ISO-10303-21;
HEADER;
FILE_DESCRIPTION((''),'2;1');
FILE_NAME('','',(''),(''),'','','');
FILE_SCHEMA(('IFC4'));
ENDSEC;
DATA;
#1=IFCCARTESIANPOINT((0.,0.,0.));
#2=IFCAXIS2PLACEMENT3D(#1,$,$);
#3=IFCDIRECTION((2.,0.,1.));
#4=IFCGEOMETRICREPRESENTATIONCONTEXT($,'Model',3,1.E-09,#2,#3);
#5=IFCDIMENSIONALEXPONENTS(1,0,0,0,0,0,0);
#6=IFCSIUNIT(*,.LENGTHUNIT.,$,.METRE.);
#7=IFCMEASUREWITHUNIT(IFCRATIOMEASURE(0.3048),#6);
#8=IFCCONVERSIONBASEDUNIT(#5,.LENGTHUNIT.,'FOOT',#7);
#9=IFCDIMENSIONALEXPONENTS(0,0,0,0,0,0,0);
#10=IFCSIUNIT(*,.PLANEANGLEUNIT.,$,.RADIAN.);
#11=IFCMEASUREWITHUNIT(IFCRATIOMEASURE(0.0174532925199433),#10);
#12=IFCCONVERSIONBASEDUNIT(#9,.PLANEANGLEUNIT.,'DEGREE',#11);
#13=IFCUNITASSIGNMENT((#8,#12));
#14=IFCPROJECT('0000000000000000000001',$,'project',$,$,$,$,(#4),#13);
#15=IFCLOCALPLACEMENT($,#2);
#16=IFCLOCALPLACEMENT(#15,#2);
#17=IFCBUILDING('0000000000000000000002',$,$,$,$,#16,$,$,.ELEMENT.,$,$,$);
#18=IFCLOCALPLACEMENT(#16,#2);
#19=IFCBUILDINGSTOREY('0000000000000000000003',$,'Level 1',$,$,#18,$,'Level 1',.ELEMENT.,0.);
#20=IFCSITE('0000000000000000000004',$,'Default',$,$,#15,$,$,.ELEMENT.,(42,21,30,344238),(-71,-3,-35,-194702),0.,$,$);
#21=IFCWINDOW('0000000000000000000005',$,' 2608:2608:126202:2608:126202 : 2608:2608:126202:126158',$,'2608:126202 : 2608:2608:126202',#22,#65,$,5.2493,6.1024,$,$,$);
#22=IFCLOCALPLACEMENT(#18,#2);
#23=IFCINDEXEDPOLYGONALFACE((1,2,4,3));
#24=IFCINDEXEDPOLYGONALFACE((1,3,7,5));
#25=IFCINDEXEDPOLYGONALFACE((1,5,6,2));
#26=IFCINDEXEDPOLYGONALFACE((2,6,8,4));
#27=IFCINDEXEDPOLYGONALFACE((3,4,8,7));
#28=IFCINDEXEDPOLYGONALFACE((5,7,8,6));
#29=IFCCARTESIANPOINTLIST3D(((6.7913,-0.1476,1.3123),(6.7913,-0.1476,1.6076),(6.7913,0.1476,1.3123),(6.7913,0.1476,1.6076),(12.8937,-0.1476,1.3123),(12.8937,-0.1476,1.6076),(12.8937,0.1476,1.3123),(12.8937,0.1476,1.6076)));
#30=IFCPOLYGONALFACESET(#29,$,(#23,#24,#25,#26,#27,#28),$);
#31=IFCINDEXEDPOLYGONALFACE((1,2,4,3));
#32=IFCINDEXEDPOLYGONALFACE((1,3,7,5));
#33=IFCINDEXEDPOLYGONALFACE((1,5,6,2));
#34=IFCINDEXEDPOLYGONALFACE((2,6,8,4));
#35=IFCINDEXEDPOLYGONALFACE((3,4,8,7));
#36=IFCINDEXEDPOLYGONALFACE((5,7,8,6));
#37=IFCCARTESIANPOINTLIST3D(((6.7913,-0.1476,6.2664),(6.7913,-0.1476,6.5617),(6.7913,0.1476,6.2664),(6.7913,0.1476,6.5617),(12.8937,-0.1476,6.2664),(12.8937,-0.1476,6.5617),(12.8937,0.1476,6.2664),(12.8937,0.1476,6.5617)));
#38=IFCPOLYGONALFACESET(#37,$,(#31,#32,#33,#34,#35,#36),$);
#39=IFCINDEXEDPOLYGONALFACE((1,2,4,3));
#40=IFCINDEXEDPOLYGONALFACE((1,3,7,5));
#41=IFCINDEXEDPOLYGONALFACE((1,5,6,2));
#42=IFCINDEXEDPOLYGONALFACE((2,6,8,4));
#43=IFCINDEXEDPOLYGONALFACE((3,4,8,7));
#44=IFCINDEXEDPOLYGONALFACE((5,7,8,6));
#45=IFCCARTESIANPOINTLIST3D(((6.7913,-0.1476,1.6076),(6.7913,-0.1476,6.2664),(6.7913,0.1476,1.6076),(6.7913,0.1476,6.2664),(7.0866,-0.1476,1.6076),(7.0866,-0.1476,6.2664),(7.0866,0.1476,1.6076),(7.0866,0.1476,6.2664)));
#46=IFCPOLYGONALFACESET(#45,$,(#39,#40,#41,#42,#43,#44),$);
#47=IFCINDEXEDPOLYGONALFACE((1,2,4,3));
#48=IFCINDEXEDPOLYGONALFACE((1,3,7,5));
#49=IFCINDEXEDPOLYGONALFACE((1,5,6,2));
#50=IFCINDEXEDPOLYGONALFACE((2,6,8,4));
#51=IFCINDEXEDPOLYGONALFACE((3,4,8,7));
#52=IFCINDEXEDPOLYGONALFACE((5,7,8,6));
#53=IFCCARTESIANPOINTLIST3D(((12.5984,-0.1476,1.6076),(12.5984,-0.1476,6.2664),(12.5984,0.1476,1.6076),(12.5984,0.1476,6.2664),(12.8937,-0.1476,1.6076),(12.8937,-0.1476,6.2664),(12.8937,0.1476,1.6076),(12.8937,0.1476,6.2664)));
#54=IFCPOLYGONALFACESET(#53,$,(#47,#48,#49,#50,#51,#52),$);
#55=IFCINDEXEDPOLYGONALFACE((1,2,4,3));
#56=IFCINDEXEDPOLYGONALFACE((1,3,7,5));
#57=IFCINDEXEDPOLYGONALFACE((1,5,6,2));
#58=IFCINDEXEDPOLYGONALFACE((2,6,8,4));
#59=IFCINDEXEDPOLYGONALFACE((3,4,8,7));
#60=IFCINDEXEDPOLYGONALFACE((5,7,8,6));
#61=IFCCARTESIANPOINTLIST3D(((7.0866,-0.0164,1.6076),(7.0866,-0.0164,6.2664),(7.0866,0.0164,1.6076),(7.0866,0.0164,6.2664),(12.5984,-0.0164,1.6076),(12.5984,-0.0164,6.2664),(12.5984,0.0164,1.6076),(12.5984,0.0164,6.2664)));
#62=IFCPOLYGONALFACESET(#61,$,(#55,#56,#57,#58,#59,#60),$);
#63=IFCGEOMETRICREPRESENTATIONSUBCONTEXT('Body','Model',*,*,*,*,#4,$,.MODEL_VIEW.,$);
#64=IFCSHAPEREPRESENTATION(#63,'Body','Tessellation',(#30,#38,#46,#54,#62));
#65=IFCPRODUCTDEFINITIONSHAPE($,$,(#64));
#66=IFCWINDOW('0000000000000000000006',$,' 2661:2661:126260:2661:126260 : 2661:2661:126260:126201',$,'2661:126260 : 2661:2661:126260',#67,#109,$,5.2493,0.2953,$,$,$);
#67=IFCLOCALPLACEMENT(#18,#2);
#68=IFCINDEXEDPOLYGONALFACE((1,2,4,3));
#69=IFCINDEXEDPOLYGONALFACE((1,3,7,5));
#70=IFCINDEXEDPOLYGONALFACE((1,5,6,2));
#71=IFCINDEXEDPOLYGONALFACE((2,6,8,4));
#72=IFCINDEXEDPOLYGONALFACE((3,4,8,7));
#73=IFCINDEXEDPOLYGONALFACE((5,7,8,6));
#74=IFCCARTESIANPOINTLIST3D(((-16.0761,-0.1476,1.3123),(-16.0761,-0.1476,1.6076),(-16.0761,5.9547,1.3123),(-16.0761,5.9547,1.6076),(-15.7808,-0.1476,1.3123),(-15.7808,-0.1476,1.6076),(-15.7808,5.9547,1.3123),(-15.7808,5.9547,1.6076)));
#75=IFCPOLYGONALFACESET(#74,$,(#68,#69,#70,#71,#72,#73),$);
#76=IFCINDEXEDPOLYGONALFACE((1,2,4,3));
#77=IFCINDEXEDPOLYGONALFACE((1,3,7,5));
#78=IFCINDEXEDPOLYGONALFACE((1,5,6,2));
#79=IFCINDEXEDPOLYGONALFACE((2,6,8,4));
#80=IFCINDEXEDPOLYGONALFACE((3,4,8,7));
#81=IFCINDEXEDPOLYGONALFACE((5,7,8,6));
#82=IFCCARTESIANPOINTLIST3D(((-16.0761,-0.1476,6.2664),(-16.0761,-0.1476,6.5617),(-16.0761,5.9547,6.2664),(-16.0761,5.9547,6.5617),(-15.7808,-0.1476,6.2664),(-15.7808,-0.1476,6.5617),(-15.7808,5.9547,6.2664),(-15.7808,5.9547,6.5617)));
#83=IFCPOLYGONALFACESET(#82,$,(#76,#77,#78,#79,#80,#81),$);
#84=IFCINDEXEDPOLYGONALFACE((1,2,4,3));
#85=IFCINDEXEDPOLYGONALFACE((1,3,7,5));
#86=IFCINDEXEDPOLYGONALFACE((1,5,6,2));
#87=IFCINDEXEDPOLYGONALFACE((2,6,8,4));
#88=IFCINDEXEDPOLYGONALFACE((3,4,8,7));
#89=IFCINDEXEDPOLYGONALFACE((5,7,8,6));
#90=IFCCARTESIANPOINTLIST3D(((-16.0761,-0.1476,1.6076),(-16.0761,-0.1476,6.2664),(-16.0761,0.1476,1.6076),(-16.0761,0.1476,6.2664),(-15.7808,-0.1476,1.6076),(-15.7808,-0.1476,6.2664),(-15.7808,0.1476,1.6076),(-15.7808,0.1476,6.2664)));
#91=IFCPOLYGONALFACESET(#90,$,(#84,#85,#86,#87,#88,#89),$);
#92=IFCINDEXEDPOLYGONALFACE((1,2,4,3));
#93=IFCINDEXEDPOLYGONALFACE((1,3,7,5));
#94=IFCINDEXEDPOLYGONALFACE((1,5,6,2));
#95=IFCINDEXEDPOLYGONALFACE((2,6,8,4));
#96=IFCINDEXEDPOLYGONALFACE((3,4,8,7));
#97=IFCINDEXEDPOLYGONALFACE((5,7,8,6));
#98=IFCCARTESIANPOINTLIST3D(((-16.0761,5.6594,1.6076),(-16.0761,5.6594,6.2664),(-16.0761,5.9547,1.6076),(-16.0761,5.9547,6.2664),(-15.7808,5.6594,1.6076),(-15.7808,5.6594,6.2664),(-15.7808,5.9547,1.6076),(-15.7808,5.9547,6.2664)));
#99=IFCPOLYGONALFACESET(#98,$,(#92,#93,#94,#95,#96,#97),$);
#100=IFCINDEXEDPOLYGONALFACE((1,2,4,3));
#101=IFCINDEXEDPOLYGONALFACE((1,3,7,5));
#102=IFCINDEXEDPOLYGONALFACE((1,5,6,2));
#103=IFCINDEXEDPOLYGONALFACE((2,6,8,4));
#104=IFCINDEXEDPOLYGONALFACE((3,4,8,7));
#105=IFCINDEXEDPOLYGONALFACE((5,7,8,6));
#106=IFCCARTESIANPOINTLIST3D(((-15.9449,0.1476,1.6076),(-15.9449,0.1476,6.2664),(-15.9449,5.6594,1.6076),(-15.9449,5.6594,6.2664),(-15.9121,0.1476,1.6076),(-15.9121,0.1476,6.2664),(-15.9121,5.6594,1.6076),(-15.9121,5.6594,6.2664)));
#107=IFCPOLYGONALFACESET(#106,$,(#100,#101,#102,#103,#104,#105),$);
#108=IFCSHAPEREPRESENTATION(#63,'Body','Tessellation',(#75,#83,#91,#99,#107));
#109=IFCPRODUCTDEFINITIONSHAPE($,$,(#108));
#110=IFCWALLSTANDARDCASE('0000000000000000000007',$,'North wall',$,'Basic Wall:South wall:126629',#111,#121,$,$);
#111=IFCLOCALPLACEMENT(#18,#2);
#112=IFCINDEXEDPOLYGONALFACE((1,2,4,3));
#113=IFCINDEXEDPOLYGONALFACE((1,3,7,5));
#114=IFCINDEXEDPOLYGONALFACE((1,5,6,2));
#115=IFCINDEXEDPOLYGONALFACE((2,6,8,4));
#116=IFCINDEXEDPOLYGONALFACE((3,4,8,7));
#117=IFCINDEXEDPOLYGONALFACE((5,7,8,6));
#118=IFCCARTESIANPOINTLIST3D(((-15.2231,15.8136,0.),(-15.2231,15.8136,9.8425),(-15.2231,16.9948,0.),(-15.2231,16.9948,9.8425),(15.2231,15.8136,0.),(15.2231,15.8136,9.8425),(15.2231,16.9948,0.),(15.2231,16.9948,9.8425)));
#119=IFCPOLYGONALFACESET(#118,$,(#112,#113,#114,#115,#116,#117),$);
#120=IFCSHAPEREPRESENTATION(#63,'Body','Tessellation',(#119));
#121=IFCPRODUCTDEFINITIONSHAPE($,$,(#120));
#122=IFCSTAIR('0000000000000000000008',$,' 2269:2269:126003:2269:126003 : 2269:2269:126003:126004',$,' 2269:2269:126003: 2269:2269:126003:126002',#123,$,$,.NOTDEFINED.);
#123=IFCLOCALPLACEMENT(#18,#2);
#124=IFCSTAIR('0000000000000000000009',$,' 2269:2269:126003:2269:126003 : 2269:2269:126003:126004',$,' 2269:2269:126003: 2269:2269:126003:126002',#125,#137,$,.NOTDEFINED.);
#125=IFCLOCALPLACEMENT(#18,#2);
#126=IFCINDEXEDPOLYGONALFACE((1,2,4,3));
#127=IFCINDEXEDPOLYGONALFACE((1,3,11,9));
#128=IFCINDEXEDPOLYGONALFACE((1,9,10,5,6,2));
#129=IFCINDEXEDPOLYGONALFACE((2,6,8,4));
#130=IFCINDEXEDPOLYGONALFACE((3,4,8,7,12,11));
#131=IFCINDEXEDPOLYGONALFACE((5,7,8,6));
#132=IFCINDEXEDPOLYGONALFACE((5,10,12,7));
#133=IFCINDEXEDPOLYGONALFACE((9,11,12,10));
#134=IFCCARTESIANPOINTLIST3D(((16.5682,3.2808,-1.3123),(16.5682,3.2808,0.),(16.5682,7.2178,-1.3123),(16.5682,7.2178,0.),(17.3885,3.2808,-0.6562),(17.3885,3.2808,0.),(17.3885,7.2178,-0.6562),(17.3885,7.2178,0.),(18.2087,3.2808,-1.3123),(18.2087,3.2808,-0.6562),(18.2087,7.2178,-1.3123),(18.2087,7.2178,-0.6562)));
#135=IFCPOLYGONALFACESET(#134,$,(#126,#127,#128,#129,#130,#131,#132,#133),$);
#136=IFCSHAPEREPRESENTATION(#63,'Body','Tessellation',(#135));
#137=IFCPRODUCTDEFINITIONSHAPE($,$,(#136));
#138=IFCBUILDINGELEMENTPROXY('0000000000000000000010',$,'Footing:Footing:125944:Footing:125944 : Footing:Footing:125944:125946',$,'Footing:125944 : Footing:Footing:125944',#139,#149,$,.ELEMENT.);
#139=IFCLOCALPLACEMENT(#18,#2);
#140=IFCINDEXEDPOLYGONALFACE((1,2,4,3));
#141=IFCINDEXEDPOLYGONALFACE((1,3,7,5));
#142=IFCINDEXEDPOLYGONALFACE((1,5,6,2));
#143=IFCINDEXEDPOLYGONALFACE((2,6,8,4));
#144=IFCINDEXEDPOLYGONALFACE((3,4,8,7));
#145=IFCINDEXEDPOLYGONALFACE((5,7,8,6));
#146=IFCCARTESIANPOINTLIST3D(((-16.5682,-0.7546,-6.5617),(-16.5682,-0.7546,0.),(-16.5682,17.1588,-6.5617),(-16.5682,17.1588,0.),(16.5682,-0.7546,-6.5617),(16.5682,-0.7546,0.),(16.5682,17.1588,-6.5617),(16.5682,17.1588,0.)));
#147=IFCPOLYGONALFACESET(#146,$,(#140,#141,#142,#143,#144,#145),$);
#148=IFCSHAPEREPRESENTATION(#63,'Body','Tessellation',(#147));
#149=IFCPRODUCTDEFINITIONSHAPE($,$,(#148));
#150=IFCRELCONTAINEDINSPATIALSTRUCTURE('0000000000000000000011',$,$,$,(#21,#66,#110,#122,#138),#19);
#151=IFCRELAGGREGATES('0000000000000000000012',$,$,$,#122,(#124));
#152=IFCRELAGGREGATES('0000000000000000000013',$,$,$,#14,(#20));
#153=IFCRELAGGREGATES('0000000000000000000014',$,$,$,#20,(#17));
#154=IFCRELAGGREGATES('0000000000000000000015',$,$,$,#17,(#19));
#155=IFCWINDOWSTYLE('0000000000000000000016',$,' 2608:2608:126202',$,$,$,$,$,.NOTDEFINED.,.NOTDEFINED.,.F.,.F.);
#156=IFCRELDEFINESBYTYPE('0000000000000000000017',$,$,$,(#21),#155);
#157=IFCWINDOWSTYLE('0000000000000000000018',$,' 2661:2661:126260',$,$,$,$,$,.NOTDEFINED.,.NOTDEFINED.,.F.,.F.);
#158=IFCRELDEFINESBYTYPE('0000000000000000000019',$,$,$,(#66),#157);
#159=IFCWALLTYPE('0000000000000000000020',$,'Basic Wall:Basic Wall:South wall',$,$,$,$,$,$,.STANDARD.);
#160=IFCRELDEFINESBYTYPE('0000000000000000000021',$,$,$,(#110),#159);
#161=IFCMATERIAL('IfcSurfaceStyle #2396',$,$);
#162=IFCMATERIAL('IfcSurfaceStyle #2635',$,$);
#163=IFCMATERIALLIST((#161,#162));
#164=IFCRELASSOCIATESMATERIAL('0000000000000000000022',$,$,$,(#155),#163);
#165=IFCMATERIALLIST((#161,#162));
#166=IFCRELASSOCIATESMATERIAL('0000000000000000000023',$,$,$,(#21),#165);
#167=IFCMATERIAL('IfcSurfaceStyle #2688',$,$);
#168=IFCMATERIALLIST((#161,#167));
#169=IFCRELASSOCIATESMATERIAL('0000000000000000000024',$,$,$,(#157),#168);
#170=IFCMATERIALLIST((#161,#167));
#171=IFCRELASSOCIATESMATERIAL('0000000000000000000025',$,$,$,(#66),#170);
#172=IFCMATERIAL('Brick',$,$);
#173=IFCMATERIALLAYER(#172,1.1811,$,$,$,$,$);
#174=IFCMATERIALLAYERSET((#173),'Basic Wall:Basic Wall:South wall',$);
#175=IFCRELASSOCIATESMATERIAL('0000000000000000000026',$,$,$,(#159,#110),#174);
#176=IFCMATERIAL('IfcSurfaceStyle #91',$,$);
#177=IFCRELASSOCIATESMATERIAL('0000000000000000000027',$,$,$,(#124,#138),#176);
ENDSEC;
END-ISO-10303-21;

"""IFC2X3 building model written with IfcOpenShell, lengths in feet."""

from ifc_helpers import new_model, entity, si_unit, converted_unit, direction, frame, frame_2d, origin, origin_2d_with_axis, place, context, subcontext, project, spatial, polyline, rectangle, outline, extrude, source, transform, mapped, material, material_list, layer, layer_set, layer_usage, type_object, type_shapes, element, aggregate, save


model = new_model("IFC2X3")

# Units and contexts
model_context = context("Model", 3, precision=1e-09, world=origin(), true_north=direction((2.0, 0.0, 1.0)))
body_context = subcontext(model_context, "Body", "Model", "MODEL_VIEW")
ifc_project = project(units=[converted_unit("LENGTHUNIT", "FOOT", entity("IfcRatioMeasure", 0.3048), si_unit("LENGTHUNIT", "METRE"), dimensions=[1, 0, 0, 0, 0, 0, 0]), converted_unit("PLANEANGLEUNIT", "DEGREE", entity("IfcRatioMeasure", 0.0174532925199433), si_unit("PLANEANGLEUNIT", "RADIAN"), dimensions=[0, 0, 0, 0, 0, 0, 0])], contexts=[model_context])

# Site, building, storey
site_placement = place(None, origin())
site = spatial("IfcSite", under=ifc_project, at=site_placement, Name="Default", CompositionType="ELEMENT", RefLatitude=(42, 21, 30, 344238), RefLongitude=(-71, -3, -35, -194702), RefElevation=0.0)
building_placement = place(site_placement, origin())
building = spatial("IfcBuilding", under=site, at=building_placement, CompositionType="ELEMENT")
storey_placement = place(building_placement, origin())
storey = spatial("IfcBuildingStorey", under=building, at=storey_placement, Name="Level 1", LongName="Level 1", CompositionType="ELEMENT", Elevation=0.0)

# Windows
ifc_material_1 = material(Name="IfcSurfaceStyle #2396")
ifc_material_2 = material(Name="IfcSurfaceStyle #2635")
ifc_material_list_1 = material_list([ifc_material_1, ifc_material_2])
ifc_material_list_2 = material_list([ifc_material_1, ifc_material_2])
window_style_1 = type_object("IfcWindowStyle", Name=" 2608:2608:126202", ConstructionType="NOTDEFINED", OperationType="NOTDEFINED", ParameterTakesPrecedence=False, Sizeable=False, material=ifc_material_list_2)
shared_shape_1 = source(origin(), body_context, "Body", "SweptSolid", [
    extrude(rectangle(XDim=6.1024, YDim=0.2953, at=frame_2d((0.0, 0.0), x_axis=(1.0, 0.0))), frame((9.8425, 0.0, 1.3123), z_axis=(0.0, 0.0, 1.0), x_axis=(-1.0, 0.0, 0.0)), (0.0, 0.0, 1.0), 0.2953),
    extrude(rectangle(XDim=6.1024, YDim=0.2953, at=frame_2d((0.0, 0.0), x_axis=(1.0, 0.0))), frame((9.8425, 0.0, 6.2664), z_axis=(0.0, 0.0, 1.0), x_axis=(-1.0, 0.0, 0.0)), (0.0, 0.0, 1.0), 0.2953),
    extrude(rectangle(XDim=0.2953, YDim=0.2953, at=origin_2d_with_axis()), frame((6.939, 0.0, 1.6076), z_axis=(0.0, 0.0, 1.0), x_axis=(-1.0, 0.0, 0.0)), (0.0, 0.0, 1.0), 4.6588),
    extrude(rectangle(XDim=0.2953, YDim=0.2953, at=frame_2d((0.0, 0.0), x_axis=(1.0, 0.0))), frame((12.7461, 0.0, 1.6076), z_axis=(0.0, 0.0, 1.0), x_axis=(-1.0, 0.0, 0.0)), (0.0, 0.0, 1.0), 4.6588),
    extrude(rectangle(XDim=5.5118, YDim=0.0328, at=frame_2d((0.0, 0.0), x_axis=(1.0, 0.0))), frame((9.8425, 0.0, 1.6076), z_axis=(0.0, 0.0, 1.0), x_axis=(-1.0, 0.0, 0.0)), (0.0, 0.0, 1.0), 4.6588),
])
type_shapes(window_style_1, [shared_shape_1])
window_1_placement = place(storey_placement, origin())
element("IfcWindow", 1, at=window_1_placement, inside=storey, type_object=window_style_1, material=ifc_material_list_1, Name=" 2608:2608:126202:2608:126202 : 2608:2608:126202:126158", ObjectType="2608:126202 : 2608:2608:126202", OverallHeight=5.2493, OverallWidth=6.1024, context=body_context, shape_type="MappedRepresentation", body=[
    mapped(shared_shape_1, transform((0.0, 0.0, 0.0), scale=1.0)),
])
ifc_material_3 = material(Name="IfcSurfaceStyle #2688")
ifc_material_list_3 = material_list([ifc_material_1, ifc_material_3])
ifc_material_list_4 = material_list([ifc_material_1, ifc_material_3])
window_style_2 = type_object("IfcWindowStyle", Name=" 2661:2661:126260", ConstructionType="NOTDEFINED", OperationType="NOTDEFINED", ParameterTakesPrecedence=False, Sizeable=False, material=ifc_material_list_4)
shared_shape_2 = source(origin(), body_context, "Body", "SweptSolid", [
    extrude(rectangle(XDim=6.1024, YDim=0.2953, at=origin_2d_with_axis()), frame((-15.9285, 2.9035, 1.3123), z_axis=(0.0, 0.0, 1.0), x_axis=(0.0, -1.0, 0.0)), (0.0, 0.0, 1.0), 0.2953),
    extrude(rectangle(XDim=6.1024, YDim=0.2953, at=origin_2d_with_axis()), frame((-15.9285, 2.9035, 6.2664), z_axis=(0.0, 0.0, 1.0), x_axis=(0.0, -1.0, 0.0)), (0.0, 0.0, 1.0), 0.2953),
    extrude(rectangle(XDim=0.2953, YDim=0.2953, at=origin_2d_with_axis()), frame((-15.9285, 0.0, 1.6076), z_axis=(0.0, 0.0, 1.0), x_axis=(0.0, -1.0, 0.0)), (0.0, 0.0, 1.0), 4.6588),
    extrude(rectangle(XDim=0.2953, YDim=0.2953, at=frame_2d((0.0, 0.0), x_axis=(1.0, 0.0))), frame((-15.9285, 5.8071, 1.6076), z_axis=(0.0, 0.0, 1.0), x_axis=(0.0, -1.0, 0.0)), (0.0, 0.0, 1.0), 4.6588),
    extrude(rectangle(XDim=5.5118, YDim=0.0328, at=origin_2d_with_axis()), frame((-15.9285, 2.9035, 1.6076), z_axis=(0.0, 0.0, 1.0), x_axis=(0.0, -1.0, 0.0)), (0.0, 0.0, 1.0), 4.6588),
])
type_shapes(window_style_2, [shared_shape_2])
window_2_placement = place(storey_placement, origin())
element("IfcWindow", 2, at=window_2_placement, inside=storey, type_object=window_style_2, material=ifc_material_list_3, Name=" 2661:2661:126260:2661:126260 : 2661:2661:126260:126201", ObjectType="2661:126260 : 2661:2661:126260", OverallHeight=5.2493, OverallWidth=0.2953, context=body_context, shape_type="MappedRepresentation", body=[
    mapped(shared_shape_2, transform((0.0, 0.0, 0.0), scale=1.0)),
])

# Shared definitions
ifc_material_4 = material(Name="Brick")
ifc_layer = layer(ifc_material_4, 1.1811)
ifc_layer_set = layer_set([ifc_layer], Name="Basic Wall:Basic Wall:South wall")
wall_type = type_object("IfcWallType", Name="Basic Wall:Basic Wall:South wall", PredefinedType="STANDARD", material=ifc_layer_set)

# Wall
ifc_layer_usage_1 = layer_usage(ifc_layer_set, "AXIS2", "NEGATIVE", 0.5906)
wall_1_placement = place(storey_placement, frame((15.2231, 16.4042, 0.0), z_axis=(0.0, 0.0, 1.0), x_axis=(-1.0, 0.0, 0.0)))
element("IfcWallStandardCase", 3, at=wall_1_placement, inside=storey, type_object=wall_type, material=ifc_layer_usage_1, Name="North wall", ObjectType="Basic Wall:South wall:126629", context=body_context, shape_type="SweptSolid", body=[
    extrude(rectangle(XDim=30.4462, YDim=1.1811, at=frame_2d((15.2231, 0.0), x_axis=(-1.0, 0.0))), origin(), (0.0, 0.0, 1.0), 9.8425),
])

# Stairs
stair_1_placement = place(storey_placement, frame((16.5682, 3.2808, -1.3123)))
stair_1 = element("IfcStair", 4, at=stair_1_placement, inside=storey, Name=" 2269:2269:126003:2269:126003 : 2269:2269:126003:126004", ObjectType=" 2269:2269:126003: 2269:2269:126003:126002", ShapeType="NOTDEFINED")
ifc_material_5 = material(Name="IfcSurfaceStyle #91")
stair_2_placement = place(stair_1_placement, origin())
stair_2 = element("IfcStair", 5, at=stair_2_placement, material=ifc_material_5, Name=" 2269:2269:126003:2269:126003 : 2269:2269:126003:126004", ObjectType=" 2269:2269:126003: 2269:2269:126003:126002", ShapeType="NOTDEFINED", context=body_context, shape_type="SweptSolid", body=[
    extrude(outline(polyline([(0.0, 0.0), (0.8202, 0.0), (0.8202, 0.6562), (-0.8202, 0.6562), (-0.8202, -0.6562), (0.0, -0.6562), (0.0, 0.0)])), frame((0.8202, 0.0, 0.6562), z_axis=(0.0, 1.0, 0.0), x_axis=(1.0, 0.0, 0.0)), (0.0, 0.0, 1.0), 3.937),
])
aggregate(stair_1, [stair_2])

# Building element proxy
shared_shape_3 = source(origin(), body_context, "Body", "SweptSolid", [
    extrude(rectangle(XDim=33.1365, YDim=17.9134, at=origin_2d_with_axis()), frame((0.0, 8.2021, -6.5617), z_axis=(0.0, 0.0, 1.0), x_axis=(-1.0, 0.0, 0.0)), (0.0, 0.0, 1.0), 6.5617),
])
proxy_placement = place(storey_placement, origin())
element("IfcBuildingElementProxy", 6, at=proxy_placement, inside=storey, material=ifc_material_5, Name="Footing:Footing:125944:Footing:125944 : Footing:Footing:125944:125946", ObjectType="Footing:125944 : Footing:Footing:125944", CompositionType="ELEMENT", context=body_context, shape_type="MappedRepresentation", body=[
    mapped(shared_shape_3, transform((0.0, 0.0, 0.0), scale=1.0)),
])

save(model, "model.ifc")
